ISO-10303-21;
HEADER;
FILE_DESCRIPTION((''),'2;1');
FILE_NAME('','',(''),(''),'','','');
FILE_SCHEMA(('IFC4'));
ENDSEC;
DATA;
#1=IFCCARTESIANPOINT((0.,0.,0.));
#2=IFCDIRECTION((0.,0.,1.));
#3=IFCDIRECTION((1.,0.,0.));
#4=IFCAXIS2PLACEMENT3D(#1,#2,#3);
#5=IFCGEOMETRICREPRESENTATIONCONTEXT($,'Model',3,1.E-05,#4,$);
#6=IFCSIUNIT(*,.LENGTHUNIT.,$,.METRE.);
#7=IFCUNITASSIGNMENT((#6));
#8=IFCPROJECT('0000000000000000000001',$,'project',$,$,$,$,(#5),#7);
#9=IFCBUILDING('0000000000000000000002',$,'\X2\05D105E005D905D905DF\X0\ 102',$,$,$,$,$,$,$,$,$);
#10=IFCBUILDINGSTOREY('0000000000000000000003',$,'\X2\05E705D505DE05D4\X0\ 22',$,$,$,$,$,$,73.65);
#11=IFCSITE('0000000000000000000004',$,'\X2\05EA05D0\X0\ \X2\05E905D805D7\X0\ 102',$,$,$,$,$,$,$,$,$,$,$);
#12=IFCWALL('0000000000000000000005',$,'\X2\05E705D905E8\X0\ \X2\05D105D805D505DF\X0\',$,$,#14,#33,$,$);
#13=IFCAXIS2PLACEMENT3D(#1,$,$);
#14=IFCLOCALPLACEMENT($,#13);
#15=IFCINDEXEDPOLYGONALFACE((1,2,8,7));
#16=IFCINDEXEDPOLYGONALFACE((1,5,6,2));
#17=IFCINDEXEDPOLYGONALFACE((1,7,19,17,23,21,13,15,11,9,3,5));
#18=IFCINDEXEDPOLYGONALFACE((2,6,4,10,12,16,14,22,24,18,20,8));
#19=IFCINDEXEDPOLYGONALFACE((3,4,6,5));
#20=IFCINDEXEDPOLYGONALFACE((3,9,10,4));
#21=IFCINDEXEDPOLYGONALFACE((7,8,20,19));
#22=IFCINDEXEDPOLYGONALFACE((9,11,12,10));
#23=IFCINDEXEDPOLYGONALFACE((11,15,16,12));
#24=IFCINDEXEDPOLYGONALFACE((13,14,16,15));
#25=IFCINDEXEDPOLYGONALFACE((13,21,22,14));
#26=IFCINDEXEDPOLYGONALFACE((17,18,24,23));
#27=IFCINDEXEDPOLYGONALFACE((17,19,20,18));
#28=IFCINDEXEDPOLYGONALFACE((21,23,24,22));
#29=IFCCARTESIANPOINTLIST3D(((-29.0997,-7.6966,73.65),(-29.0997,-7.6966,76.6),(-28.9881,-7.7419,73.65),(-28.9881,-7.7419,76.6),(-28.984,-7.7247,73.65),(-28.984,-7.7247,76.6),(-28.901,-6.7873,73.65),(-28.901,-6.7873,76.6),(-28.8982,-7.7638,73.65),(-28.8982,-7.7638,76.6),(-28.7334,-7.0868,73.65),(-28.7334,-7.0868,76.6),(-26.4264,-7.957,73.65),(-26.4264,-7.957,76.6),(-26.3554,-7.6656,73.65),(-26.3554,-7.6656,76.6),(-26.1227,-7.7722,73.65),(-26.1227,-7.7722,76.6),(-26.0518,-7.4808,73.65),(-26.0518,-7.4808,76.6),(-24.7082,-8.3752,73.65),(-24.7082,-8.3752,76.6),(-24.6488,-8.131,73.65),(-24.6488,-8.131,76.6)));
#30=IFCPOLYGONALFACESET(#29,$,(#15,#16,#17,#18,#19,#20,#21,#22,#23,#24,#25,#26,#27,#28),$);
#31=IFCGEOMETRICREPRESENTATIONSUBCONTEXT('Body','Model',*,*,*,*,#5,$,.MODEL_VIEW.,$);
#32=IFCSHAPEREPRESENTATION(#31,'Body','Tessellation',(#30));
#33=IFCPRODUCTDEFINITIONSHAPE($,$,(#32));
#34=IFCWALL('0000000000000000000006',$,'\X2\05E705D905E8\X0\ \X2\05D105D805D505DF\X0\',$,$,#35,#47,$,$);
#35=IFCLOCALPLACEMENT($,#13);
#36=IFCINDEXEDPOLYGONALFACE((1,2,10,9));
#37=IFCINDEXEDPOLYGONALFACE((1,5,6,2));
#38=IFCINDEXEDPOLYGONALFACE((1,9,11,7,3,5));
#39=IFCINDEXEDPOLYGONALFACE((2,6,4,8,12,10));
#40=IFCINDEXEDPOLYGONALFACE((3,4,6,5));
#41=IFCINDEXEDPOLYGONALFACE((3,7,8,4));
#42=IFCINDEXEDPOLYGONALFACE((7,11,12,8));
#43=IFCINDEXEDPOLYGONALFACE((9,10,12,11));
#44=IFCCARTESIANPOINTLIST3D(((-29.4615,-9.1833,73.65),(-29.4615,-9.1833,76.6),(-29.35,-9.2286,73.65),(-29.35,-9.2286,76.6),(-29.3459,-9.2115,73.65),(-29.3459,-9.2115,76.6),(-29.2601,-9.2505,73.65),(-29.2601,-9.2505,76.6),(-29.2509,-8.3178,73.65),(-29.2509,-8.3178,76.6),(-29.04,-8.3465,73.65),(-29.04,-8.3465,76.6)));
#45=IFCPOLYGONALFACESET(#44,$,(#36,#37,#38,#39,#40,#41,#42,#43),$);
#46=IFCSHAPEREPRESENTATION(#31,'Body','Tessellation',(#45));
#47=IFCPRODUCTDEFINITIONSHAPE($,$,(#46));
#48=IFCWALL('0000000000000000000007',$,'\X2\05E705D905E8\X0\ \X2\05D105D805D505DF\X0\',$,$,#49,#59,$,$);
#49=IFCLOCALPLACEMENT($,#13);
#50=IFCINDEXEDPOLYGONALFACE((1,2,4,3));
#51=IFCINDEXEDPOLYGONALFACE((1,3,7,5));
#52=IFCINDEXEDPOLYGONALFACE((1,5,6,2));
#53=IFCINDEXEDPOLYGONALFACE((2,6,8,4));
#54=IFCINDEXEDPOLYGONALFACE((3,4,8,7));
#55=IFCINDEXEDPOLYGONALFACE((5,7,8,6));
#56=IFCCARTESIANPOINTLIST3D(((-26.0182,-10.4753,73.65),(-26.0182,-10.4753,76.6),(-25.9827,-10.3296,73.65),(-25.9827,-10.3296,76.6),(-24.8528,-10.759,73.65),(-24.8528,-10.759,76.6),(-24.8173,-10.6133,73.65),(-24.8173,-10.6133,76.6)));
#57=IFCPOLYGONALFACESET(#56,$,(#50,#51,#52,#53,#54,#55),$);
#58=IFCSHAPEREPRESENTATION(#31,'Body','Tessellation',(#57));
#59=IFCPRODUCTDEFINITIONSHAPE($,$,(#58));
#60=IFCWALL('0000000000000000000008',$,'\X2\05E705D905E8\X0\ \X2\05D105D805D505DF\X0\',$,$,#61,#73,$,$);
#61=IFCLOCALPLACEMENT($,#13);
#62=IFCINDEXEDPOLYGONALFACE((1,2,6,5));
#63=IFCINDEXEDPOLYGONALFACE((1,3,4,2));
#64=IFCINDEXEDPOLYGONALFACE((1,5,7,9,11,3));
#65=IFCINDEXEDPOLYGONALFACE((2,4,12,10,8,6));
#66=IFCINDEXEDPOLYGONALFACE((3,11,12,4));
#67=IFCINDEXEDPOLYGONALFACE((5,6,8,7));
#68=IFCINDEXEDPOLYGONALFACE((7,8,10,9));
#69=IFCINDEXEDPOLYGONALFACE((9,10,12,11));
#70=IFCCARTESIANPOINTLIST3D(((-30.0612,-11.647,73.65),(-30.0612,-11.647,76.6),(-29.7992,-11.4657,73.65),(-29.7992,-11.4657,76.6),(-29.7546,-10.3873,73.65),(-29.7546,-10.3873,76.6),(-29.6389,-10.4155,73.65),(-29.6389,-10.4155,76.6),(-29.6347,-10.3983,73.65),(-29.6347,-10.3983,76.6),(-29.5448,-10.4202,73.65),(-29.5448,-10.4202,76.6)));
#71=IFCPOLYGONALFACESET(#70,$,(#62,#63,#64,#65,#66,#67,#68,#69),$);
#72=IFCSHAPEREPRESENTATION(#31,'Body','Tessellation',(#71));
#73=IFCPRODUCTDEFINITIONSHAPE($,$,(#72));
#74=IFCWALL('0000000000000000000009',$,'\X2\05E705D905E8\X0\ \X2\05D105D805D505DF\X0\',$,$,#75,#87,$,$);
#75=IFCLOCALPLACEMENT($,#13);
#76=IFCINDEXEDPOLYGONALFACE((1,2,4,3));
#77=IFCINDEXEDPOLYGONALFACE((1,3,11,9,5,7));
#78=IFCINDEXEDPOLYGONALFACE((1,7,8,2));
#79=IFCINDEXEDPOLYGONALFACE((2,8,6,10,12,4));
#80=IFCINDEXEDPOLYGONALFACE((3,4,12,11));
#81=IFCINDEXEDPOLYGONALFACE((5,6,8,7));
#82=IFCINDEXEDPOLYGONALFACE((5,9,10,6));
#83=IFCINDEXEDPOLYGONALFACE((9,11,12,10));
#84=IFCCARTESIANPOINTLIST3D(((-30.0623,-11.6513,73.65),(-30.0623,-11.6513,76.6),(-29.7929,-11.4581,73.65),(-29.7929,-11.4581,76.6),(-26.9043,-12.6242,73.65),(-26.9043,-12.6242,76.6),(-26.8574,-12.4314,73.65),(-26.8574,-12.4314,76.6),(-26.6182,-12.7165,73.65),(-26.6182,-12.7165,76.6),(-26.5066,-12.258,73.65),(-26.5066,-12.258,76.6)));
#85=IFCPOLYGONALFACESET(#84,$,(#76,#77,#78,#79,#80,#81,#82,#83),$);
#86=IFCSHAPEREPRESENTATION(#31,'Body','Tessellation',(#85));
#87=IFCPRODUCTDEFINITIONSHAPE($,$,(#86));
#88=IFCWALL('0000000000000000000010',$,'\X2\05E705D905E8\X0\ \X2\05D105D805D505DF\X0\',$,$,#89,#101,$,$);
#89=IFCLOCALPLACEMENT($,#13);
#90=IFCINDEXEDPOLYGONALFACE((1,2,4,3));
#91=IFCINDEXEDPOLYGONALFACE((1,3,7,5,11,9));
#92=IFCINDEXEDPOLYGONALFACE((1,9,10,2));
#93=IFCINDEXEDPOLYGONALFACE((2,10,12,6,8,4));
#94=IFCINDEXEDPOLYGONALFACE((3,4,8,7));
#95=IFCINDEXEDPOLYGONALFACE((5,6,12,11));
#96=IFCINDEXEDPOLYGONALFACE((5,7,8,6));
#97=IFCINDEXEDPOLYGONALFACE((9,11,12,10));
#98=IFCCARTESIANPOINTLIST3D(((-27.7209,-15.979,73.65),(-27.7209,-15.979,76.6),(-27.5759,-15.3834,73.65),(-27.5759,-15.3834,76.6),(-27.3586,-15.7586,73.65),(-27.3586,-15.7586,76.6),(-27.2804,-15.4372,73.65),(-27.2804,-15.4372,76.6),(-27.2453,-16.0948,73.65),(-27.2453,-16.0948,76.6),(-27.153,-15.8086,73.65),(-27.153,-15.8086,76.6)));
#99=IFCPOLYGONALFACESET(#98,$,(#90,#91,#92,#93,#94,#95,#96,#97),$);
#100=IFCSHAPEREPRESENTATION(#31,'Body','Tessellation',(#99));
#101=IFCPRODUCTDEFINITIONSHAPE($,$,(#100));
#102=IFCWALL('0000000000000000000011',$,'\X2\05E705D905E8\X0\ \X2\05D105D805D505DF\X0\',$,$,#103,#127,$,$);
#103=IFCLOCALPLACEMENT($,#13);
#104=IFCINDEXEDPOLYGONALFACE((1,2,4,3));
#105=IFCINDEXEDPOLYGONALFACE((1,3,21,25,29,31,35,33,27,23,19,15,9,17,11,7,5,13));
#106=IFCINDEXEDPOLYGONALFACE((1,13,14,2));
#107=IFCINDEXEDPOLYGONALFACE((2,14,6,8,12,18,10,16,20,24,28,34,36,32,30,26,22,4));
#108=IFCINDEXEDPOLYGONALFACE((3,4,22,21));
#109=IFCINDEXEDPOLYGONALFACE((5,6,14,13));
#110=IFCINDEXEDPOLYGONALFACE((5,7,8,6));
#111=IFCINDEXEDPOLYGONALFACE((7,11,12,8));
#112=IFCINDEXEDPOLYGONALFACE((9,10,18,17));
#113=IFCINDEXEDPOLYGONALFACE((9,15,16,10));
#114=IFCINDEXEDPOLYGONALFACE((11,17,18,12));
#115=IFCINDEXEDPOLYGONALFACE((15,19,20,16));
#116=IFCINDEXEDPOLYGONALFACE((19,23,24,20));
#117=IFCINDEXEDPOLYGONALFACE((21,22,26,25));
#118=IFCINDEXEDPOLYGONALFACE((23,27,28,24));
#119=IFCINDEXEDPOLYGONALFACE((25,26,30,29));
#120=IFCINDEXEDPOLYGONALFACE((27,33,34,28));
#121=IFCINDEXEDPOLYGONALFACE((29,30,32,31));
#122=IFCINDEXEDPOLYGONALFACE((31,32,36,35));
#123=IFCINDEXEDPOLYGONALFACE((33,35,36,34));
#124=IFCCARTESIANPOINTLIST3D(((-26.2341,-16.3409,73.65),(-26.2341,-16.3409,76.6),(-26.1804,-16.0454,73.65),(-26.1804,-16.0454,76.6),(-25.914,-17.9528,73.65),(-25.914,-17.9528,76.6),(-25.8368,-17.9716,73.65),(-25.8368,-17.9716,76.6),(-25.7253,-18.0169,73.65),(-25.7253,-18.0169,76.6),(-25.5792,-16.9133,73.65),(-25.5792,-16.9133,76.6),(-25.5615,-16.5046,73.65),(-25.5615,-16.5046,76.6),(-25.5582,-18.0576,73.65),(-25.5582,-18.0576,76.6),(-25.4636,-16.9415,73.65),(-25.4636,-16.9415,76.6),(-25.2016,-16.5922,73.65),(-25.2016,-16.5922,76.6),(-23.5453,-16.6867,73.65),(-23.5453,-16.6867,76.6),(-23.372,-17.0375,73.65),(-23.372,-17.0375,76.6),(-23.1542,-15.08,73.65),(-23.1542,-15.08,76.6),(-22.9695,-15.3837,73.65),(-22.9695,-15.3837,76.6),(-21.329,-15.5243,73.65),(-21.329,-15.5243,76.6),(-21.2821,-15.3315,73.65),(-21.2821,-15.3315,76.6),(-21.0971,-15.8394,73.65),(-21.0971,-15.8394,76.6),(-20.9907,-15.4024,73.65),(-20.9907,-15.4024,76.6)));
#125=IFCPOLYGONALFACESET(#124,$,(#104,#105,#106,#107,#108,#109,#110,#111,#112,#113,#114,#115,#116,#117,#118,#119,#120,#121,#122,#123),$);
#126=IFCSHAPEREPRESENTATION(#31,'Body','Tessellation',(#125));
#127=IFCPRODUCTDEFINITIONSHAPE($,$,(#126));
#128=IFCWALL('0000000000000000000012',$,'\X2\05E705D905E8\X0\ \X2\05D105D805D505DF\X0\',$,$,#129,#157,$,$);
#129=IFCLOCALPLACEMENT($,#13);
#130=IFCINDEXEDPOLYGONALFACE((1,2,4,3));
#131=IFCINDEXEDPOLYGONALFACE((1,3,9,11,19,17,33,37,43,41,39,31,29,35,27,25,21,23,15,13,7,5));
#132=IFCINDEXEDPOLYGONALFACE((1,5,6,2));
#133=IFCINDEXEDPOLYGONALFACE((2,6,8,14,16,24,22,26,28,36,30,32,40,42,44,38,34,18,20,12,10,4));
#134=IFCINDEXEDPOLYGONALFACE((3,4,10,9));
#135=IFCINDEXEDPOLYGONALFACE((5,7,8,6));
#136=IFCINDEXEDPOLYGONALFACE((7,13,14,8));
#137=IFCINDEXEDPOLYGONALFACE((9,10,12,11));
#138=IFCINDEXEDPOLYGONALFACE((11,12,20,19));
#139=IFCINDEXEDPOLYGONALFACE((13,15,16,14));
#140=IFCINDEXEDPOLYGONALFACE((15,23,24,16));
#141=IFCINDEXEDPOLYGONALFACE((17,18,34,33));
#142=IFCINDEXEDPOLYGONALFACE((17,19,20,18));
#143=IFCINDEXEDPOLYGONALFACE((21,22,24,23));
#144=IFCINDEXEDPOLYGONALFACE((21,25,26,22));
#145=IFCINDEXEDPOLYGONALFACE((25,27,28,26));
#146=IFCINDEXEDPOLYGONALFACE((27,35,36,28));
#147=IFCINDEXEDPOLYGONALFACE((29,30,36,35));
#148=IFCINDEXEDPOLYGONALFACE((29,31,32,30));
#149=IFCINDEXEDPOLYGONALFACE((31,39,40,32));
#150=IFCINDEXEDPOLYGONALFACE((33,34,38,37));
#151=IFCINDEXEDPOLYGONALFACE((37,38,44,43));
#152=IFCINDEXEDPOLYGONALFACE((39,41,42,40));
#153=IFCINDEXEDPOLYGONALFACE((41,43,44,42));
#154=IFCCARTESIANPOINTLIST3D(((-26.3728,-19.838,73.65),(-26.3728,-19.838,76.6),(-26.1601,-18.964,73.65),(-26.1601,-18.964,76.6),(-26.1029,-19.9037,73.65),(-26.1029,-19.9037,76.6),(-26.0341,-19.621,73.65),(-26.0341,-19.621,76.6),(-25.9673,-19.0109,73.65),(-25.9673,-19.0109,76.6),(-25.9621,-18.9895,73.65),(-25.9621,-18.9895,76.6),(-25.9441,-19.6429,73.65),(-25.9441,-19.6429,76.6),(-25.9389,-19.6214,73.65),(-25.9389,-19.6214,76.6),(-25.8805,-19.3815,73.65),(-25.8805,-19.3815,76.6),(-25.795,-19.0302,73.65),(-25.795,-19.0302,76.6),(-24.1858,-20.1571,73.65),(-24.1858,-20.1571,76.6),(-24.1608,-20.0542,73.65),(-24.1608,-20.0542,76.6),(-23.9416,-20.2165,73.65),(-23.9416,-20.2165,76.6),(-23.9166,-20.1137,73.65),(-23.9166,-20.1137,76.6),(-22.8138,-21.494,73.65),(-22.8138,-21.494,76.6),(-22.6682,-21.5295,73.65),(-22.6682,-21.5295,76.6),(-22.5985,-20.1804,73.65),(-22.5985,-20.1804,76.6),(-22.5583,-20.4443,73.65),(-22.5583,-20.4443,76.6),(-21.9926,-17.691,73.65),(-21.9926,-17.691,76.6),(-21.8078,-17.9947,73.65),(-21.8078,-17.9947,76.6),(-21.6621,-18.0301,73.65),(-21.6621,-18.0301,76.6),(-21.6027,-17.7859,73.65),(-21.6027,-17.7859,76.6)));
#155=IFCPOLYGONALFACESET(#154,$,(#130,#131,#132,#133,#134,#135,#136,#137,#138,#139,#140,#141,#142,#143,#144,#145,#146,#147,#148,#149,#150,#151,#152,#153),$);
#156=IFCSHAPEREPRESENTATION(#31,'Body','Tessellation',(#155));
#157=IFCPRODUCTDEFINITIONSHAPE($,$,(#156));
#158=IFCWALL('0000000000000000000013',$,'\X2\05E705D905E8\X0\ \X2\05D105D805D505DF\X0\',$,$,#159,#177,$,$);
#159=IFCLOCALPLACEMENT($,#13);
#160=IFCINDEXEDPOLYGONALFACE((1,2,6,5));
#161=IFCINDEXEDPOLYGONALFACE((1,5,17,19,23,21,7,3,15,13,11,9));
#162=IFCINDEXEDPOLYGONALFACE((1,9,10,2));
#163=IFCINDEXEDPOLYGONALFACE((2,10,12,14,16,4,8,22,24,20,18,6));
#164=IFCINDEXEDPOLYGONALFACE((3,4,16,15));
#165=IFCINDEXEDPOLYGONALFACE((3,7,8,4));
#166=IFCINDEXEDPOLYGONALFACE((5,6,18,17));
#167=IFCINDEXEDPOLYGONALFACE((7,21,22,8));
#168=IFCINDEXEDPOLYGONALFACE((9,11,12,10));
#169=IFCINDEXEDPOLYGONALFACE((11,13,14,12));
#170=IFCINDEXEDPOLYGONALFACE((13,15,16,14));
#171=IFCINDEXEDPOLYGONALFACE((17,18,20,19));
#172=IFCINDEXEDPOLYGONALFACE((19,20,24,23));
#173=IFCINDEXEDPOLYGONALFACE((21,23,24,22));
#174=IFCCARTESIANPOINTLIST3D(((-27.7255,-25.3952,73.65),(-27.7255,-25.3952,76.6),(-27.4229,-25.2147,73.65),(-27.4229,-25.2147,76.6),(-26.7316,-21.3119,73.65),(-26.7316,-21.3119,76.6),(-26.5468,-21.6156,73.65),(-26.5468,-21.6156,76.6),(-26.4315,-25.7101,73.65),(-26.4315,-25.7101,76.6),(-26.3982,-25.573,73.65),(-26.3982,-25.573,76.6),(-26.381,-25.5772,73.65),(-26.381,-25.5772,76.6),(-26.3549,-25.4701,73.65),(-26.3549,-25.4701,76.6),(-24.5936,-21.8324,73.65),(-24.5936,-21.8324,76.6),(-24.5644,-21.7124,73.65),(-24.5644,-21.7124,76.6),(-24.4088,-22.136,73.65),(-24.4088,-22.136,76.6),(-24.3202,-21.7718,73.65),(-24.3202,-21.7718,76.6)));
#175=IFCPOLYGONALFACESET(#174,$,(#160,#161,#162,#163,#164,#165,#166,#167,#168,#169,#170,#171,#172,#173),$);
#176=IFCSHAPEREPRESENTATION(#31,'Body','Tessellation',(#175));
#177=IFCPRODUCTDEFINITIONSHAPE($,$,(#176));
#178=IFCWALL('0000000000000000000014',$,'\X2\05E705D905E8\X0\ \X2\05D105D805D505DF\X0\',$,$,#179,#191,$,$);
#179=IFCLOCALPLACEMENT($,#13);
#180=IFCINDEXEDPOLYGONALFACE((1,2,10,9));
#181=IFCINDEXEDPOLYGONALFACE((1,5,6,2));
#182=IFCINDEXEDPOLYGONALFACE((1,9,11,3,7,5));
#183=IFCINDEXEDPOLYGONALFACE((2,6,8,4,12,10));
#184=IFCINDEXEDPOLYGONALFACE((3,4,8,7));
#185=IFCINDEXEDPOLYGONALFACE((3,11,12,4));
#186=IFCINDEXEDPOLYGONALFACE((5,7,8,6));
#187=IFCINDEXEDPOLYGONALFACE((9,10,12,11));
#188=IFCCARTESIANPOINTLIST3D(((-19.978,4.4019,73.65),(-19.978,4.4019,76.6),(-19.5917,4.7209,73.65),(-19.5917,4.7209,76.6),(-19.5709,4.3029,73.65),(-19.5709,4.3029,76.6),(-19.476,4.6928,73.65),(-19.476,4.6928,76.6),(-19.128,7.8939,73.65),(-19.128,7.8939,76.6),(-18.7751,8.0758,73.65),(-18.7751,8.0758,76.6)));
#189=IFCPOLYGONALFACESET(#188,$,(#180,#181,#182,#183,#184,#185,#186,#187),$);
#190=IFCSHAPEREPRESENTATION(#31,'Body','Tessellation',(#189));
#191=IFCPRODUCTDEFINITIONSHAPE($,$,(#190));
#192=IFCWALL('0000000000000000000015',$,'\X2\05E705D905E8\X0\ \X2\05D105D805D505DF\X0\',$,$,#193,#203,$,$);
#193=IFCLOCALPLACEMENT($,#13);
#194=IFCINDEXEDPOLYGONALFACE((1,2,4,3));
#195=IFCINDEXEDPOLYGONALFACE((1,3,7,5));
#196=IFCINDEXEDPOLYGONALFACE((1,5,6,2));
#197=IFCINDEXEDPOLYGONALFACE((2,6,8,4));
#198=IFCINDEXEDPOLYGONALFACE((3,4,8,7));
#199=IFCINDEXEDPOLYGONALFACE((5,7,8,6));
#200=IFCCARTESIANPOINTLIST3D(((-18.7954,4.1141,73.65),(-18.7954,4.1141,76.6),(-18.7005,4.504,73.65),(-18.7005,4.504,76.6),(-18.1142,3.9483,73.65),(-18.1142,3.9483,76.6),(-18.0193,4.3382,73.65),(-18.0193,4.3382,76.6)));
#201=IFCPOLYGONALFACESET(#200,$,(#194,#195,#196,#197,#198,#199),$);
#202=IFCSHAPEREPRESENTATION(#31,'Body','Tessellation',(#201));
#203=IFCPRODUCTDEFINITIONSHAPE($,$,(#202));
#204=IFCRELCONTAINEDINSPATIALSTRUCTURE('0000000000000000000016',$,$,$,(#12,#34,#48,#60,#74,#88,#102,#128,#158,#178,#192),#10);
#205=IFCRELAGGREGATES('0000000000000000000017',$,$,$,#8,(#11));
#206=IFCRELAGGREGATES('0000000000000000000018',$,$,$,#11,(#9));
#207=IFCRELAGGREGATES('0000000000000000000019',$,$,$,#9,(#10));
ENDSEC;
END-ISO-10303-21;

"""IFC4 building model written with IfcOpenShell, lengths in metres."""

from ifc_helpers import new_model, si_unit, frame, origin_with_axes, context, subcontext, project, spatial, polyline, outline, extrude, element, save


model = new_model("IFC4")

# Units and contexts
model_context = context("Model", 3, precision=1e-05, world=origin_with_axes())
body_context = subcontext(model_context, "Body", "Model", "MODEL_VIEW")
ifc_project = project(units=[si_unit("LENGTHUNIT", "METRE")], contexts=[model_context])

# Site, building, storey
site = spatial("IfcSite", under=ifc_project, Name="תא שטח 102")
building = spatial("IfcBuilding", under=site, Name="בניין 102")
storey = spatial("IfcBuildingStorey", under=building, Name="קומה 22", Elevation=73.65)

# Walls
element("IfcWall", 1, inside=storey, Name="קיר בטון", context=body_context, shape_type="SweptSolid", body=[
    extrude(outline(polyline([(-28.984, -7.7247), (-28.9881, -7.7419), (-28.8982, -7.7638), (-28.7334, -7.0868), (-26.3554, -7.6656), (-26.4264, -7.957), (-24.7082, -8.3752), (-24.6488, -8.131), (-26.1227, -7.7722), (-26.0518, -7.4808), (-28.901, -6.7873), (-29.0997, -7.6966), (-28.984, -7.7247)])), frame((0.0, 0.0, 73.65)), (0.0, 0.0, 1.0), 2.95),
])
element("IfcWall", 2, inside=storey, Name="קיר בטון", context=body_context, shape_type="SweptSolid", body=[
    extrude(outline(polyline([(-29.3459, -9.2115), (-29.35, -9.2286), (-29.2601, -9.2505), (-29.04, -8.3465), (-29.2509, -8.3178), (-29.4615, -9.1833), (-29.3459, -9.2115)])), frame((0.0, 0.0, 73.65)), (0.0, 0.0, 1.0), 2.95),
])
element("IfcWall", 3, inside=storey, Name="קיר בטון", context=body_context, shape_type="SweptSolid", body=[
    extrude(outline(polyline([(-25.9827, -10.3296), (-26.0182, -10.4753), (-24.8528, -10.759), (-24.8173, -10.6133), (-25.9827, -10.3296)])), frame((0.0, 0.0, 73.65)), (0.0, 0.0, 1.0), 2.95),
])
element("IfcWall", 4, inside=storey, Name="קיר בטון", context=body_context, shape_type="SweptSolid", body=[
    extrude(outline(polyline([(-29.7992, -11.4657), (-29.5448, -10.4202), (-29.6347, -10.3983), (-29.6389, -10.4155), (-29.7546, -10.3873), (-30.0612, -11.647), (-29.7992, -11.4657)])), frame((0.0, 0.0, 73.65)), (0.0, 0.0, 1.0), 2.95),
])
element("IfcWall", 5, inside=storey, Name="קיר בטון", context=body_context, shape_type="SweptSolid", body=[
    extrude(outline(polyline([(-26.5066, -12.258), (-29.7929, -11.4581), (-30.0623, -11.6513), (-26.8574, -12.4314), (-26.9043, -12.6242), (-26.6182, -12.7165), (-26.5066, -12.258)])), frame((0.0, 0.0, 73.65)), (0.0, 0.0, 1.0), 2.95),
])
element("IfcWall", 6, inside=storey, Name="קיר בטון", context=body_context, shape_type="SweptSolid", body=[
    extrude(outline(polyline([(-27.7209, -15.979), (-27.2453, -16.0948), (-27.153, -15.8086), (-27.3586, -15.7586), (-27.2804, -15.4372), (-27.5759, -15.3834), (-27.7209, -15.979)])), frame((0.0, 0.0, 73.65)), (0.0, 0.0, 1.0), 2.95),
])
element("IfcWall", 7, inside=storey, Name="קיר בטון", context=body_context, shape_type="SweptSolid", body=[
    extrude(outline(polyline([(-25.5582, -18.0576), (-25.2016, -16.5922), (-23.372, -17.0375), (-22.9695, -15.3837), (-21.0971, -15.8394), (-20.9907, -15.4024), (-21.2821, -15.3315), (-21.329, -15.5243), (-23.1542, -15.08), (-23.5453, -16.6867), (-26.1804, -16.0454), (-26.2341, -16.3409), (-25.5615, -16.5046), (-25.914, -17.9528), (-25.8368, -17.9716), (-25.5792, -16.9133), (-25.4636, -16.9415), (-25.7253, -18.0169), (-25.5582, -18.0576)])), frame((0.0, 0.0, 73.65)), (0.0, 0.0, 1.0), 2.95),
])
element("IfcWall", 8, inside=storey, Name="קיר בטון", context=body_context, shape_type="SweptSolid", body=[
    extrude(outline(polyline([(-25.9673, -19.0109), (-26.1601, -18.964), (-26.3728, -19.838), (-26.1029, -19.9037), (-26.0341, -19.621), (-25.9441, -19.6429), (-25.9389, -19.6214), (-24.1608, -20.0542), (-24.1858, -20.1571), (-23.9416, -20.2165), (-23.9166, -20.1137), (-22.5583, -20.4443), (-22.8138, -21.494), (-22.6682, -21.5295), (-21.8078, -17.9947), (-21.6621, -18.0301), (-21.6027, -17.7859), (-21.9926, -17.691), (-22.5985, -20.1804), (-25.8805, -19.3815), (-25.795, -19.0302), (-25.9621, -18.9895), (-25.9673, -19.0109)])), frame((0.0, 0.0, 73.65)), (0.0, 0.0, 1.0), 2.95),
])
element("IfcWall", 9, inside=storey, Name="קיר בטון", context=body_context, shape_type="SweptSolid", body=[
    extrude(outline(polyline([(-27.7255, -25.3952), (-26.4315, -25.7101), (-26.3982, -25.573), (-26.381, -25.5772), (-26.3549, -25.4701), (-27.4229, -25.2147), (-26.5468, -21.6156), (-24.4088, -22.136), (-24.3202, -21.7718), (-24.5644, -21.7124), (-24.5936, -21.8324), (-26.7316, -21.3119), (-27.7255, -25.3952)])), frame((0.0, 0.0, 73.65)), (0.0, 0.0, 1.0), 2.95),
])
element("IfcWall", 10, inside=storey, Name="קיר בטון", context=body_context, shape_type="SweptSolid", body=[
    extrude(outline(polyline([(-18.7751, 8.0758), (-19.128, 7.8939), (-19.978, 4.4019), (-19.5709, 4.3029), (-19.476, 4.6928), (-19.5917, 4.7209), (-18.7751, 8.0758)])), frame((0.0, 0.0, 73.65)), (0.0, 0.0, 1.0), 2.95),
])
element("IfcWall", 11, inside=storey, Name="קיר בטון", context=body_context, shape_type="SweptSolid", body=[
    extrude(outline(polyline([(-18.7005, 4.504), (-18.7954, 4.1141), (-18.1142, 3.9483), (-18.0193, 4.3382), (-18.7005, 4.504)])), frame((0.0, 0.0, 73.65)), (0.0, 0.0, 1.0), 2.95),
])

save(model, "model.ifc")
